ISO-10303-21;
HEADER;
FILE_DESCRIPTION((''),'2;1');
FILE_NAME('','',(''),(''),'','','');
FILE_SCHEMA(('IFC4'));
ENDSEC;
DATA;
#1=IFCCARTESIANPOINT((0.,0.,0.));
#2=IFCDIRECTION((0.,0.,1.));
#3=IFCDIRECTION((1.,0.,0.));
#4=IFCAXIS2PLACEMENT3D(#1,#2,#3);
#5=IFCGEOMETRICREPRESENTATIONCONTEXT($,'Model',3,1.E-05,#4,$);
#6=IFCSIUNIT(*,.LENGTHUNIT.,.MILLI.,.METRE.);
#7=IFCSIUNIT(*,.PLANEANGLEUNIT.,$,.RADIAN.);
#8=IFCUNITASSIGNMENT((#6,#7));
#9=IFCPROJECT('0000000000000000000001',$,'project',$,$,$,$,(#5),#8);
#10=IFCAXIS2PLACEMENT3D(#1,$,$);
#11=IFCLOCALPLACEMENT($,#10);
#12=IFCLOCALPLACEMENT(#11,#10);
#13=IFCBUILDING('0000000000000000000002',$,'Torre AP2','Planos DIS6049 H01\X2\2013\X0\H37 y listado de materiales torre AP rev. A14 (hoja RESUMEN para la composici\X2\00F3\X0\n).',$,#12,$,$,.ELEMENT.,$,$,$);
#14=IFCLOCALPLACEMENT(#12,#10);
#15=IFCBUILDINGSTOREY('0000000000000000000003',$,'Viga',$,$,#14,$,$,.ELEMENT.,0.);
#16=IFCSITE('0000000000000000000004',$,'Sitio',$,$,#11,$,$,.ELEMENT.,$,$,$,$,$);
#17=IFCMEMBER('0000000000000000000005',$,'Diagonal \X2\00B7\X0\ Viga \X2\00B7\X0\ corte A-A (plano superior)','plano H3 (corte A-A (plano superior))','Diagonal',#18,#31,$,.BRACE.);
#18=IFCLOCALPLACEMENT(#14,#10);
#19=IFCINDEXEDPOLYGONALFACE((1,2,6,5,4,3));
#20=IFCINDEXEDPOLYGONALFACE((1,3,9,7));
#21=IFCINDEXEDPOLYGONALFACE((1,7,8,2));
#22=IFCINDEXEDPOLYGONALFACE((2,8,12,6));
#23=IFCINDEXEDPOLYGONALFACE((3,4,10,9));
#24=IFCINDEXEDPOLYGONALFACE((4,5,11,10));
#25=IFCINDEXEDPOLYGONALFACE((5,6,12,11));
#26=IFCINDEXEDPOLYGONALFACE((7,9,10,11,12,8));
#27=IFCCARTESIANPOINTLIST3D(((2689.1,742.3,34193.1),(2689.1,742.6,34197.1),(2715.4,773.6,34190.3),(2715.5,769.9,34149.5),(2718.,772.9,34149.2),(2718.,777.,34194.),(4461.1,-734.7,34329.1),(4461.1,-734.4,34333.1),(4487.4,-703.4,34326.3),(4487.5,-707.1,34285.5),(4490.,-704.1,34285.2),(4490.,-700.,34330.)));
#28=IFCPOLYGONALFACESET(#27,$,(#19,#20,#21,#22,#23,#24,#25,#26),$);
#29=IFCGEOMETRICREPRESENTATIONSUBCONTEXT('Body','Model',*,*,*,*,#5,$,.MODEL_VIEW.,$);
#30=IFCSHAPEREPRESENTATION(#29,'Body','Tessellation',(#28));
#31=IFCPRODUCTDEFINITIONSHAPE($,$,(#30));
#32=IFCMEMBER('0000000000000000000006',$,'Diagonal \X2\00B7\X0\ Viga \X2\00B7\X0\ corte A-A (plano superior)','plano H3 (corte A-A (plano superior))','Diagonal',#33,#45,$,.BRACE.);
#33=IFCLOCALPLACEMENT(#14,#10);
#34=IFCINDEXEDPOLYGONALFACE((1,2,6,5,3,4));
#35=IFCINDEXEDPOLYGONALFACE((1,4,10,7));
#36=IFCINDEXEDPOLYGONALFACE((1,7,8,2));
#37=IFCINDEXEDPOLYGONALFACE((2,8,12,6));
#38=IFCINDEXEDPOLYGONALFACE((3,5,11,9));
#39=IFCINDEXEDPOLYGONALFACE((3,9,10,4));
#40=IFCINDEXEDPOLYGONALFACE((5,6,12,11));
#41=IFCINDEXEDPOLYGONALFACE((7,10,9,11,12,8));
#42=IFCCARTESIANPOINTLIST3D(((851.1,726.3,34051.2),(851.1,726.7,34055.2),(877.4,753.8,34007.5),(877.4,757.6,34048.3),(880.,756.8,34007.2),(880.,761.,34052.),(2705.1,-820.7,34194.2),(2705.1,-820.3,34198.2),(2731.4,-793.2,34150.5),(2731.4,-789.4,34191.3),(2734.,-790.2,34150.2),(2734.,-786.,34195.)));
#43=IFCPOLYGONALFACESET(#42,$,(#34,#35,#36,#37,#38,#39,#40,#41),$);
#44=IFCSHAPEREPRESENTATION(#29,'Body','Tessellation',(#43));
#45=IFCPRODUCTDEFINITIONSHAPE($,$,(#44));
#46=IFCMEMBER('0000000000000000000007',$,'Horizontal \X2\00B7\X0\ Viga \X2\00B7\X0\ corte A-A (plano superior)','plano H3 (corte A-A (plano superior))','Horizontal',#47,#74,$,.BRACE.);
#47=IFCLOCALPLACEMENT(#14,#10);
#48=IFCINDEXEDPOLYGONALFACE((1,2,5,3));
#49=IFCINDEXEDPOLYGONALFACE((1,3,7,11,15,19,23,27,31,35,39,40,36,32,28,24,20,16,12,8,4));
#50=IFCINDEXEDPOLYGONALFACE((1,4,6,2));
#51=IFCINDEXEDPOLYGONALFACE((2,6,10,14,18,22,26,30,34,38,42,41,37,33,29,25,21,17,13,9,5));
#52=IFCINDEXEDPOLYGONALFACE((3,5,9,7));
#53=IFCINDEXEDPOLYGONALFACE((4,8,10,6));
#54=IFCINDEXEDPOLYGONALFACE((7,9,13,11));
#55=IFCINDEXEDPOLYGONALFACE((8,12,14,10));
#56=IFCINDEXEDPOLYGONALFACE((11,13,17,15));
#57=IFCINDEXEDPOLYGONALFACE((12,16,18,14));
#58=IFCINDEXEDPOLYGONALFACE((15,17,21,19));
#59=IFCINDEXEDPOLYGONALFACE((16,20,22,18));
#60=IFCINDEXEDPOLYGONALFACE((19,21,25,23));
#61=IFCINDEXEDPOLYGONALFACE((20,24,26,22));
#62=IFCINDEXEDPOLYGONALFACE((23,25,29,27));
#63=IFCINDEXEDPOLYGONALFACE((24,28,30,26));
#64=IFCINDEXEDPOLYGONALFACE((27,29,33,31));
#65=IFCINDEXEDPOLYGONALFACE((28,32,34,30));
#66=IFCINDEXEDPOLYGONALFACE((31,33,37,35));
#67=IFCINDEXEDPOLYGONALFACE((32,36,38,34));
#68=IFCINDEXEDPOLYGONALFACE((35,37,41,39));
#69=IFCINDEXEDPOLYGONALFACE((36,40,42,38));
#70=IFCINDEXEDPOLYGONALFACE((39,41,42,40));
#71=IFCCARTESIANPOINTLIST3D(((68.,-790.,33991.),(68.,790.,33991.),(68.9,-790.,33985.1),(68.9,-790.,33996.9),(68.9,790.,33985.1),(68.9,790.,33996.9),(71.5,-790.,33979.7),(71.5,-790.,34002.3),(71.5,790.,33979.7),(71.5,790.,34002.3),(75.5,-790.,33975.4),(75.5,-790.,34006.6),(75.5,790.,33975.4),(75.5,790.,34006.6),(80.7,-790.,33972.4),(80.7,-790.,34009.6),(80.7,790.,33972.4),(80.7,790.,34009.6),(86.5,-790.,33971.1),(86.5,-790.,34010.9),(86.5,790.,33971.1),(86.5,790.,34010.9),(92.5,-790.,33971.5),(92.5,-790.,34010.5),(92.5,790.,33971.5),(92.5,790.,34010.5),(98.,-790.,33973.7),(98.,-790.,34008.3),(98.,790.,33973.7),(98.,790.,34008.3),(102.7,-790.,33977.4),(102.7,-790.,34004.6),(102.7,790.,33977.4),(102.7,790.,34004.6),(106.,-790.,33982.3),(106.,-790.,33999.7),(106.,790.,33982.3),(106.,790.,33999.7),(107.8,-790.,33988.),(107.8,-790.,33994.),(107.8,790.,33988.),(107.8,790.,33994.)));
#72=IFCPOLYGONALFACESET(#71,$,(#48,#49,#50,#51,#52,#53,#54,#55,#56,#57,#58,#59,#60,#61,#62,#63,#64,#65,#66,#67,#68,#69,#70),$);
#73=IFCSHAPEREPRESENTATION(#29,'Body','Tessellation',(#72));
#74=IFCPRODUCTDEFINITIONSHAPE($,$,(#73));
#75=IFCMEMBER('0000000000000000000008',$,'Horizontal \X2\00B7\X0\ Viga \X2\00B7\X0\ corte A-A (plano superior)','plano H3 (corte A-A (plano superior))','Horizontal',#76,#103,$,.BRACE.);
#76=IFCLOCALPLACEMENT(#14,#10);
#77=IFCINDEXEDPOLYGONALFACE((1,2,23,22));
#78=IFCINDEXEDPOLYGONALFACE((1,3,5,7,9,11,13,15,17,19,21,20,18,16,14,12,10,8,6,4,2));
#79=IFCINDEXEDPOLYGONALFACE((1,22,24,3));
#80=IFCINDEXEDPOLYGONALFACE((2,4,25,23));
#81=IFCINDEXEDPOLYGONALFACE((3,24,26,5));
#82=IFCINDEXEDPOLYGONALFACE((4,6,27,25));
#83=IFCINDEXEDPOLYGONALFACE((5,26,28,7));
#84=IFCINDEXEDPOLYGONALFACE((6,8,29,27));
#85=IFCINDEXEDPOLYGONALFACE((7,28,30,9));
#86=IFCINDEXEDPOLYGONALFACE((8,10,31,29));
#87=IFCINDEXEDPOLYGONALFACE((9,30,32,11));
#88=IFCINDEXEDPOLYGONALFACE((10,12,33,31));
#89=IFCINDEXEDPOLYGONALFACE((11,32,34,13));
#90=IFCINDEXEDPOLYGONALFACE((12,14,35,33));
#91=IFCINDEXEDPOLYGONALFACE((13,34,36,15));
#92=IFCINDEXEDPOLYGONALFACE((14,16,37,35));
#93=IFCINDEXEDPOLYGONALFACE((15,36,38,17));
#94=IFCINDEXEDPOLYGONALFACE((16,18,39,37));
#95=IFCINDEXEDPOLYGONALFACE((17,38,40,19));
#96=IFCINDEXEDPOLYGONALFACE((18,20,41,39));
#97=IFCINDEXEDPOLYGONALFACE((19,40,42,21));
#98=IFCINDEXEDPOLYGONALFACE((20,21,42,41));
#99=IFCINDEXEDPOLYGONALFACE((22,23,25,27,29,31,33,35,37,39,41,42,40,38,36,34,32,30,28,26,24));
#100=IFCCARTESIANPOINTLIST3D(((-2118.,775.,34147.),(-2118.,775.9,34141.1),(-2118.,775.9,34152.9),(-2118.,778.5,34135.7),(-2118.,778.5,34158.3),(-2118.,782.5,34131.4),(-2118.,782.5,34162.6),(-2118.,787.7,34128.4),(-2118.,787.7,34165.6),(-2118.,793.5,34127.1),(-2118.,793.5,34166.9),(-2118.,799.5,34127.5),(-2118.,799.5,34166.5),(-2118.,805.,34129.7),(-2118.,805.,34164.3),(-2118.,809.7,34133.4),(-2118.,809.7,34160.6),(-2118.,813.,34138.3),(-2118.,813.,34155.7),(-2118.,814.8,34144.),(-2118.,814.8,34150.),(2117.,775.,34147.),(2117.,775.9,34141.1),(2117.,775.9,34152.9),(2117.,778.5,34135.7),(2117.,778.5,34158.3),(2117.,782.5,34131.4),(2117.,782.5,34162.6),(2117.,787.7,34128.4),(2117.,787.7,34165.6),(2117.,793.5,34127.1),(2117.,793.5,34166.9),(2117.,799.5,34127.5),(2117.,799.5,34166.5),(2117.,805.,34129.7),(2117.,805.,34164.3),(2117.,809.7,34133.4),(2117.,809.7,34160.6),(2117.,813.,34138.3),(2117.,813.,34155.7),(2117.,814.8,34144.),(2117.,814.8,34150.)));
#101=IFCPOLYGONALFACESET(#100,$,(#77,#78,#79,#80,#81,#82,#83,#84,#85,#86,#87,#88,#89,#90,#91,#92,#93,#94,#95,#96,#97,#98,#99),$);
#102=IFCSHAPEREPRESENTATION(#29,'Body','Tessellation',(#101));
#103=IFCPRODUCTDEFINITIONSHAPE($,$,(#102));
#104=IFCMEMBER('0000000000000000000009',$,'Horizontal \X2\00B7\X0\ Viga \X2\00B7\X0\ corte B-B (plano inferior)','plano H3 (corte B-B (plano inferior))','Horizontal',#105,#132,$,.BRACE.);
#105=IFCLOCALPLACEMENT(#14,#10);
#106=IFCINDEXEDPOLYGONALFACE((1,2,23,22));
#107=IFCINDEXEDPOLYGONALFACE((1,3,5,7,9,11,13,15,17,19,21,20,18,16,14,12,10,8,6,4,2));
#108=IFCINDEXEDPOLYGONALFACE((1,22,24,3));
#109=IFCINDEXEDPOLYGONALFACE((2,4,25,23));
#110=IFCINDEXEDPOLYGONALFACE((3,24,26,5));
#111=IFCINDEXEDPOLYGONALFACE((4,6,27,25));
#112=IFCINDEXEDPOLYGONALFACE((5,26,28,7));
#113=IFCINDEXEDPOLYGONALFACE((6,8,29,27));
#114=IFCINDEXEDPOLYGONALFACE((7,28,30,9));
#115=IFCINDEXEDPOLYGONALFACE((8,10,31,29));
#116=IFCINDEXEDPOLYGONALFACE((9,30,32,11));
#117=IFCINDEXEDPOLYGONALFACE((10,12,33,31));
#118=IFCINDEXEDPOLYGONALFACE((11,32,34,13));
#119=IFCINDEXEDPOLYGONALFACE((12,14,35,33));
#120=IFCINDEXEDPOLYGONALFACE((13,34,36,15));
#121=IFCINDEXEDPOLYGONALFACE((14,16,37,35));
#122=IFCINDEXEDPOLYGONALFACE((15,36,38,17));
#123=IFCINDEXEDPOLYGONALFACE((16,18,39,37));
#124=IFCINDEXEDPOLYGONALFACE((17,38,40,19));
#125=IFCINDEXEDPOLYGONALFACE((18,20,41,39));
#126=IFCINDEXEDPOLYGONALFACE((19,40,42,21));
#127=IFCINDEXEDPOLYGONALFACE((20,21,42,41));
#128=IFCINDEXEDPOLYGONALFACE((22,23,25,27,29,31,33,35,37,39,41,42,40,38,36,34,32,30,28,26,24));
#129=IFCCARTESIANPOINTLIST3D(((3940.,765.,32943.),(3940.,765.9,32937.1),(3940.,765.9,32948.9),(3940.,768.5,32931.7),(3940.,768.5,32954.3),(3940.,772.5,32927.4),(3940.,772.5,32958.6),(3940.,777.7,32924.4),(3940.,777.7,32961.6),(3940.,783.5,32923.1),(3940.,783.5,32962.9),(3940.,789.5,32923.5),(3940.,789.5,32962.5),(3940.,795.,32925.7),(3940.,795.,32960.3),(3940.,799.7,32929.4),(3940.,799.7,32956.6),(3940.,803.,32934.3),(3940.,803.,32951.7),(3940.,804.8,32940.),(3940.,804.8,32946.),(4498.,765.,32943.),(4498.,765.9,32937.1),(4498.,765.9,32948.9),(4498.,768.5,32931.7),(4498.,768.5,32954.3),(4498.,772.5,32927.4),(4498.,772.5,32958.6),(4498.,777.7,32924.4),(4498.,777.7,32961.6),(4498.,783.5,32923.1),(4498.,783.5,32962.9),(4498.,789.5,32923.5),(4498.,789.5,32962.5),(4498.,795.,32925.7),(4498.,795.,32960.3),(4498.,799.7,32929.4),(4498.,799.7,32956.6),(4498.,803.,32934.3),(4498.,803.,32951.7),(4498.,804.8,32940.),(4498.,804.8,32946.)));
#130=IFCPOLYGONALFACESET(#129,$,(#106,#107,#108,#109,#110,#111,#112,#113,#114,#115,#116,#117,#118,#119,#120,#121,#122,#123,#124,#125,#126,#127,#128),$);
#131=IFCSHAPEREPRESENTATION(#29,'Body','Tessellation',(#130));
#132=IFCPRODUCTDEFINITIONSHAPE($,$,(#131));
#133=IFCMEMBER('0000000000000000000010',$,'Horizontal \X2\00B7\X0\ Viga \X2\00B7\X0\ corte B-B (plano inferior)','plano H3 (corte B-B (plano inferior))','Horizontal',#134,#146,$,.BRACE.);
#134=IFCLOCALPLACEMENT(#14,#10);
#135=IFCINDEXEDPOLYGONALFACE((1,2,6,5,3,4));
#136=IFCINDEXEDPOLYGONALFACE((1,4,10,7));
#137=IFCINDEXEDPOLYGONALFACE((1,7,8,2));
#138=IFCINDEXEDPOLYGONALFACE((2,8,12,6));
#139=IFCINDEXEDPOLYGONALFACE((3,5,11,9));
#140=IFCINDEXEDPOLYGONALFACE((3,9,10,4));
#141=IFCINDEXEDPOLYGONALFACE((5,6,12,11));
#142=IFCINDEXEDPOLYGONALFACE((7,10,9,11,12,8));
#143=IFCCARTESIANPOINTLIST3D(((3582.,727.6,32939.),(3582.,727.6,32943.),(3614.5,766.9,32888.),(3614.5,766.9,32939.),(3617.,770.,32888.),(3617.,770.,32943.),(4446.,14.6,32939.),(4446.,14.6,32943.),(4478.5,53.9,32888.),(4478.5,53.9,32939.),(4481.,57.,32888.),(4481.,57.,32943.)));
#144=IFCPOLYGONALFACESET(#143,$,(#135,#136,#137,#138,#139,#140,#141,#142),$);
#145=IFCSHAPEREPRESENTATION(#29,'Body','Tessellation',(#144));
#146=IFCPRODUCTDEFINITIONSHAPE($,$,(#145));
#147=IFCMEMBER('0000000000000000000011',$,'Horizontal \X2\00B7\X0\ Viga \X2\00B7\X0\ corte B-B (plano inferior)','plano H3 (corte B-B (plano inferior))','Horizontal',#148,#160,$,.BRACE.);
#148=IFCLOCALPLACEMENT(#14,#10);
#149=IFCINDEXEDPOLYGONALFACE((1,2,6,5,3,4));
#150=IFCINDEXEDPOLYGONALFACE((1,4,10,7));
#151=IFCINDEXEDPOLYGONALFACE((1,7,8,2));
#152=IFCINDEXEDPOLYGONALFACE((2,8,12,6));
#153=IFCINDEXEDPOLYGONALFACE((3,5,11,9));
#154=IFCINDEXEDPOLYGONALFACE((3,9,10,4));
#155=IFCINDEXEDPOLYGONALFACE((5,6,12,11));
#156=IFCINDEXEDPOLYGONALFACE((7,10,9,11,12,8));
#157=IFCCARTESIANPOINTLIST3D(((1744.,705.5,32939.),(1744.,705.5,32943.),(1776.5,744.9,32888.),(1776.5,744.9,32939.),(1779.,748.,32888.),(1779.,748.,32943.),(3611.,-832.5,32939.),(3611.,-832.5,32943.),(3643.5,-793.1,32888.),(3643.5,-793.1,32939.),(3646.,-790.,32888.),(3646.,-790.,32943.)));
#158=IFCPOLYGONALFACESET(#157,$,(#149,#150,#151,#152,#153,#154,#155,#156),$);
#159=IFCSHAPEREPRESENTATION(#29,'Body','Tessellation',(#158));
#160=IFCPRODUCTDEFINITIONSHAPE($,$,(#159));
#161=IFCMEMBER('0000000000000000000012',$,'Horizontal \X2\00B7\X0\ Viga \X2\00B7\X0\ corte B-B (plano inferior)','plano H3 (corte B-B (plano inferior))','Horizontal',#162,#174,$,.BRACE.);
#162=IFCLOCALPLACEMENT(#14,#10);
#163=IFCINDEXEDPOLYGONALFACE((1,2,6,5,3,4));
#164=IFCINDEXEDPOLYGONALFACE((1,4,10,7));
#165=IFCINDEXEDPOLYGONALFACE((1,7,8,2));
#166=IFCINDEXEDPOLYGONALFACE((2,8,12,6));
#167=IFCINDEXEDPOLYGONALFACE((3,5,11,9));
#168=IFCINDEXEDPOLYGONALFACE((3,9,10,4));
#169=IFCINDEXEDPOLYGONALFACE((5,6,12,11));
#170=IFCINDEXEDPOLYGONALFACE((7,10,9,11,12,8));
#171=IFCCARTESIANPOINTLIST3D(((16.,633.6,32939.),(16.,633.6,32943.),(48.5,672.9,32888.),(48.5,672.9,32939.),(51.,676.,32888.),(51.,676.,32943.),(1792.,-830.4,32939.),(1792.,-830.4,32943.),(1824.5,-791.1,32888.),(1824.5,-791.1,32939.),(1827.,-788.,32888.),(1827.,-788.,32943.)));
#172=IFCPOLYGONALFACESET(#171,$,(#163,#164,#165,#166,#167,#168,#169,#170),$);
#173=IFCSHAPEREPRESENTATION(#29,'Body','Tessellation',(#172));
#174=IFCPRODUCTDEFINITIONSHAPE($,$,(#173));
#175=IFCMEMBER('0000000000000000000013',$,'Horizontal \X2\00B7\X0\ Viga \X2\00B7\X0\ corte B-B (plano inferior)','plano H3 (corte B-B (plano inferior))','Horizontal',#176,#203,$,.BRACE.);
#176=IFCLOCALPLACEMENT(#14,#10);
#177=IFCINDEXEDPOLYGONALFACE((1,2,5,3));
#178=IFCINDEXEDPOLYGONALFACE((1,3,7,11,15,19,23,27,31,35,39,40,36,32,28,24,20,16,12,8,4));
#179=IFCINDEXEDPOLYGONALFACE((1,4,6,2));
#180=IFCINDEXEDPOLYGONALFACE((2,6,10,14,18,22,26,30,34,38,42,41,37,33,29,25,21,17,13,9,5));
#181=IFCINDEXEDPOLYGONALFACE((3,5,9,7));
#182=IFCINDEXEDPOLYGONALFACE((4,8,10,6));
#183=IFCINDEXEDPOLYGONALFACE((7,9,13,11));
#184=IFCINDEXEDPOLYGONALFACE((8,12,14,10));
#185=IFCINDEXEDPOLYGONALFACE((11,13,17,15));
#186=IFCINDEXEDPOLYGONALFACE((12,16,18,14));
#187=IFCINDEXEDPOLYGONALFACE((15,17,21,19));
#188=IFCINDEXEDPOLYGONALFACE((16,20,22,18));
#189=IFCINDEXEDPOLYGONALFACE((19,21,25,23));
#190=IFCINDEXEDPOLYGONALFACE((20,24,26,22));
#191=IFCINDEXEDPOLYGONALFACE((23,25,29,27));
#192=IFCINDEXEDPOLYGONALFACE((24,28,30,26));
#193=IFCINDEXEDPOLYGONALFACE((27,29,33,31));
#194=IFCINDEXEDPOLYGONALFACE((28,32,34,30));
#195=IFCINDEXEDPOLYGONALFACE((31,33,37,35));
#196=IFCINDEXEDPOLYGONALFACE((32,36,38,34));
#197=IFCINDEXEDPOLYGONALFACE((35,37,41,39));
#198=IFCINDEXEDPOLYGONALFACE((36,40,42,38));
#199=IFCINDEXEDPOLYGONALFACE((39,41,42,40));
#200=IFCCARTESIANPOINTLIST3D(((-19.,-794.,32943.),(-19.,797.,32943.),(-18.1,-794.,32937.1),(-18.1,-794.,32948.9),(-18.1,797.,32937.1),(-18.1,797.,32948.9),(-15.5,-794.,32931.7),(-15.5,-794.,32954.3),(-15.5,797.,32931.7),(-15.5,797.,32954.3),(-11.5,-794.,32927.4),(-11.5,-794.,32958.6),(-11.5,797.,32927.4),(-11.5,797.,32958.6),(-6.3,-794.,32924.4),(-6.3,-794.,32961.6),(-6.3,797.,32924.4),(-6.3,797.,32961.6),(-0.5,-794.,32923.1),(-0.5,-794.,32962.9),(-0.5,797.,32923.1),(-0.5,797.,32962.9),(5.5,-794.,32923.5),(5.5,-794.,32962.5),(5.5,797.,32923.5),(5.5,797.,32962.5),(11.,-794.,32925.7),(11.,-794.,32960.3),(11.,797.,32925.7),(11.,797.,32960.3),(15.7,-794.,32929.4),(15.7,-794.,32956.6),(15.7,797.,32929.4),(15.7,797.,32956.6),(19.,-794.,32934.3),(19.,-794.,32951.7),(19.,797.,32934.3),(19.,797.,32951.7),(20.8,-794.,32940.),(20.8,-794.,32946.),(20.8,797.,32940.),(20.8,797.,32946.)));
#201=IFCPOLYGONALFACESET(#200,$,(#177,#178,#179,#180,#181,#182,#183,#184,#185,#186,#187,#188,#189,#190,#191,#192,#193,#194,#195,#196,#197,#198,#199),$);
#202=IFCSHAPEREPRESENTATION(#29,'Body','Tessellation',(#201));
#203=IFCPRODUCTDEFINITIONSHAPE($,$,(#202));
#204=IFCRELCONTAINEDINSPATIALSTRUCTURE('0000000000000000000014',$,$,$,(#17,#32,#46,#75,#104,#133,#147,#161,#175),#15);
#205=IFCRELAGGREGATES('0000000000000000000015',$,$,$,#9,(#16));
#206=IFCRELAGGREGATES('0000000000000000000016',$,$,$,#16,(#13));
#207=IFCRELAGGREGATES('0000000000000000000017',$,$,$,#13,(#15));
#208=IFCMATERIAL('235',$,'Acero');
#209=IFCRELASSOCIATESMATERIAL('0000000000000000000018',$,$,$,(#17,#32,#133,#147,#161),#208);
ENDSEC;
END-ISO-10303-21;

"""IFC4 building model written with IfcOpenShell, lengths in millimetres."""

from ifc_helpers import new_model, si_unit, frame, frame_2d, origin, origin_with_axes, place, context, subcontext, project, spatial, circle, l_section, extrude, material, element, save


model = new_model("IFC4")

# Units and contexts
model_context = context("Model", 3, precision=1e-05, world=origin_with_axes())
body_context = subcontext(model_context, "Body", "Model", "MODEL_VIEW")
ifc_project = project(units=[si_unit("LENGTHUNIT", "METRE", prefix="MILLI"), si_unit("PLANEANGLEUNIT", "RADIAN")], contexts=[model_context])

# Site, building, storey
site_placement = place(None, origin())
site = spatial("IfcSite", under=ifc_project, at=site_placement, Name="Sitio", CompositionType="ELEMENT")
building_placement = place(site_placement, origin())
building = spatial("IfcBuilding", under=site, at=building_placement, Name="Torre AP2", Description="Planos DIS6049 H01–H37 y listado de materiales torre AP rev. A14 (hoja RESUMEN para la composición).", CompositionType="ELEMENT")
storey_placement = place(building_placement, origin())
storey = spatial("IfcBuildingStorey", under=building, at=storey_placement, Name="Viga", CompositionType="ELEMENT", Elevation=0.0)

# Members
ifc_material = material(Name="235", Category="Acero")
member_1_placement = place(storey_placement, frame((2718.0, 777.0, 34194.0), z_axis=(0.766819, -0.63916, 0.058853), x_axis=(-0.641863, -0.763726, 0.06881)))
element("IfcMember", 1, at=member_1_placement, inside=storey, material=ifc_material, Name="Diagonal · Viga · corte A-A (plano superior)", Description="plano H3 (corte A-A (plano superior))", ObjectType="Diagonal", PredefinedType="BRACE", context=body_context, shape_type="SweptSolid", body=[
    extrude(l_section(Depth=45.0, Width=45.0, Thickness=4.0, at=frame_2d((22.5, 22.5))), None, (0.0, 0.0, 1.0), 2310.8),
])
member_2_placement = place(storey_placement, frame((880.0, 761.0, 34052.0), z_axis=(0.766471, -0.639553, 0.059118), x_axis=(-0.642279, -0.763125, 0.071545)))
element("IfcMember", 2, at=member_2_placement, inside=storey, material=ifc_material, Name="Diagonal · Viga · corte A-A (plano superior)", Description="plano H3 (corte A-A (plano superior))", ObjectType="Diagonal", PredefinedType="BRACE", context=body_context, shape_type="SweptSolid", body=[
    extrude(l_section(Depth=45.0, Width=45.0, Thickness=4.0, at=frame_2d((22.5, 22.5))), None, (0.0, 0.0, 1.0), 2418.9),
])
member_3_placement = place(storey_placement, frame((88.0, 790.0, 33991.0), z_axis=(0.0, -1.0, 0.0), x_axis=(-1.0, 0.0, 0.0)))
element("IfcMember", 3, at=member_3_placement, inside=storey, Name="Horizontal · Viga · corte A-A (plano superior)", Description="plano H3 (corte A-A (plano superior))", ObjectType="Horizontal", PredefinedType="BRACE", context=body_context, shape_type="SweptSolid", body=[
    extrude(circle(Radius=20.0), None, (0.0, 0.0, 1.0), 1580.0),
])
member_4_placement = place(storey_placement, frame((2117.0, 795.0, 34147.0), z_axis=(-1.0, 0.0, 0.0), x_axis=(0.0, -1.0, 0.0)))
element("IfcMember", 4, at=member_4_placement, inside=storey, Name="Horizontal · Viga · corte A-A (plano superior)", Description="plano H3 (corte A-A (plano superior))", ObjectType="Horizontal", PredefinedType="BRACE", context=body_context, shape_type="SweptSolid", body=[
    extrude(circle(Radius=20.0), None, (0.0, 0.0, 1.0), 4235.0),
])
member_5_placement = place(storey_placement, frame((3940.0, 785.0, 32943.0), z_axis=(1.0, 0.0, 0.0), x_axis=(0.0, -1.0, 0.0)))
element("IfcMember", 5, at=member_5_placement, inside=storey, Name="Horizontal · Viga · corte B-B (plano inferior)", Description="plano H3 (corte B-B (plano inferior))", ObjectType="Horizontal", PredefinedType="BRACE", context=body_context, shape_type="SweptSolid", body=[
    extrude(circle(Radius=20.0), None, (0.0, 0.0, 1.0), 558.0),
])
member_6_placement = place(storey_placement, frame((3617.0, 770.0, 32943.0), z_axis=(0.771286, -0.636489, 0.0), x_axis=(-0.636489, -0.771286, 0.0)))
element("IfcMember", 6, at=member_6_placement, inside=storey, material=ifc_material, Name="Horizontal · Viga · corte B-B (plano inferior)", Description="plano H3 (corte B-B (plano inferior))", ObjectType="Horizontal", PredefinedType="BRACE", context=body_context, shape_type="SweptSolid", body=[
    extrude(l_section(Depth=55.0, Width=55.0, Thickness=4.0, at=frame_2d((27.5, 27.5))), None, (0.0, 0.0, 1.0), 1120.2),
])
member_7_placement = place(storey_placement, frame((1779.0, 748.0, 32943.0), z_axis=(0.771835, -0.635823, 0.0), x_axis=(-0.635823, -0.771835, 0.0)))
element("IfcMember", 7, at=member_7_placement, inside=storey, material=ifc_material, Name="Horizontal · Viga · corte B-B (plano inferior)", Description="plano H3 (corte B-B (plano inferior))", ObjectType="Horizontal", PredefinedType="BRACE", context=body_context, shape_type="SweptSolid", body=[
    extrude(l_section(Depth=55.0, Width=55.0, Thickness=4.0, at=frame_2d((27.5, 27.5))), None, (0.0, 0.0, 1.0), 2418.9),
])
member_8_placement = place(storey_placement, frame((51.0, 676.0, 32943.0), z_axis=(0.771629, -0.636073, 0.0), x_axis=(-0.636073, -0.771629, 0.0)))
element("IfcMember", 8, at=member_8_placement, inside=storey, material=ifc_material, Name="Horizontal · Viga · corte B-B (plano inferior)", Description="plano H3 (corte B-B (plano inferior))", ObjectType="Horizontal", PredefinedType="BRACE", context=body_context, shape_type="SweptSolid", body=[
    extrude(l_section(Depth=55.0, Width=55.0, Thickness=4.0, at=frame_2d((27.5, 27.5))), None, (0.0, 0.0, 1.0), 2301.6),
])
member_9_placement = place(storey_placement, frame((1.0, 797.0, 32943.0), z_axis=(0.0, -1.0, 0.0), x_axis=(-1.0, 0.0, 0.0)))
element("IfcMember", 9, at=member_9_placement, inside=storey, Name="Horizontal · Viga · corte B-B (plano inferior)", Description="plano H3 (corte B-B (plano inferior))", ObjectType="Horizontal", PredefinedType="BRACE", context=body_context, shape_type="SweptSolid", body=[
    extrude(circle(Radius=20.0), None, (0.0, 0.0, 1.0), 1591.0),
])

save(model, "model.ifc")
